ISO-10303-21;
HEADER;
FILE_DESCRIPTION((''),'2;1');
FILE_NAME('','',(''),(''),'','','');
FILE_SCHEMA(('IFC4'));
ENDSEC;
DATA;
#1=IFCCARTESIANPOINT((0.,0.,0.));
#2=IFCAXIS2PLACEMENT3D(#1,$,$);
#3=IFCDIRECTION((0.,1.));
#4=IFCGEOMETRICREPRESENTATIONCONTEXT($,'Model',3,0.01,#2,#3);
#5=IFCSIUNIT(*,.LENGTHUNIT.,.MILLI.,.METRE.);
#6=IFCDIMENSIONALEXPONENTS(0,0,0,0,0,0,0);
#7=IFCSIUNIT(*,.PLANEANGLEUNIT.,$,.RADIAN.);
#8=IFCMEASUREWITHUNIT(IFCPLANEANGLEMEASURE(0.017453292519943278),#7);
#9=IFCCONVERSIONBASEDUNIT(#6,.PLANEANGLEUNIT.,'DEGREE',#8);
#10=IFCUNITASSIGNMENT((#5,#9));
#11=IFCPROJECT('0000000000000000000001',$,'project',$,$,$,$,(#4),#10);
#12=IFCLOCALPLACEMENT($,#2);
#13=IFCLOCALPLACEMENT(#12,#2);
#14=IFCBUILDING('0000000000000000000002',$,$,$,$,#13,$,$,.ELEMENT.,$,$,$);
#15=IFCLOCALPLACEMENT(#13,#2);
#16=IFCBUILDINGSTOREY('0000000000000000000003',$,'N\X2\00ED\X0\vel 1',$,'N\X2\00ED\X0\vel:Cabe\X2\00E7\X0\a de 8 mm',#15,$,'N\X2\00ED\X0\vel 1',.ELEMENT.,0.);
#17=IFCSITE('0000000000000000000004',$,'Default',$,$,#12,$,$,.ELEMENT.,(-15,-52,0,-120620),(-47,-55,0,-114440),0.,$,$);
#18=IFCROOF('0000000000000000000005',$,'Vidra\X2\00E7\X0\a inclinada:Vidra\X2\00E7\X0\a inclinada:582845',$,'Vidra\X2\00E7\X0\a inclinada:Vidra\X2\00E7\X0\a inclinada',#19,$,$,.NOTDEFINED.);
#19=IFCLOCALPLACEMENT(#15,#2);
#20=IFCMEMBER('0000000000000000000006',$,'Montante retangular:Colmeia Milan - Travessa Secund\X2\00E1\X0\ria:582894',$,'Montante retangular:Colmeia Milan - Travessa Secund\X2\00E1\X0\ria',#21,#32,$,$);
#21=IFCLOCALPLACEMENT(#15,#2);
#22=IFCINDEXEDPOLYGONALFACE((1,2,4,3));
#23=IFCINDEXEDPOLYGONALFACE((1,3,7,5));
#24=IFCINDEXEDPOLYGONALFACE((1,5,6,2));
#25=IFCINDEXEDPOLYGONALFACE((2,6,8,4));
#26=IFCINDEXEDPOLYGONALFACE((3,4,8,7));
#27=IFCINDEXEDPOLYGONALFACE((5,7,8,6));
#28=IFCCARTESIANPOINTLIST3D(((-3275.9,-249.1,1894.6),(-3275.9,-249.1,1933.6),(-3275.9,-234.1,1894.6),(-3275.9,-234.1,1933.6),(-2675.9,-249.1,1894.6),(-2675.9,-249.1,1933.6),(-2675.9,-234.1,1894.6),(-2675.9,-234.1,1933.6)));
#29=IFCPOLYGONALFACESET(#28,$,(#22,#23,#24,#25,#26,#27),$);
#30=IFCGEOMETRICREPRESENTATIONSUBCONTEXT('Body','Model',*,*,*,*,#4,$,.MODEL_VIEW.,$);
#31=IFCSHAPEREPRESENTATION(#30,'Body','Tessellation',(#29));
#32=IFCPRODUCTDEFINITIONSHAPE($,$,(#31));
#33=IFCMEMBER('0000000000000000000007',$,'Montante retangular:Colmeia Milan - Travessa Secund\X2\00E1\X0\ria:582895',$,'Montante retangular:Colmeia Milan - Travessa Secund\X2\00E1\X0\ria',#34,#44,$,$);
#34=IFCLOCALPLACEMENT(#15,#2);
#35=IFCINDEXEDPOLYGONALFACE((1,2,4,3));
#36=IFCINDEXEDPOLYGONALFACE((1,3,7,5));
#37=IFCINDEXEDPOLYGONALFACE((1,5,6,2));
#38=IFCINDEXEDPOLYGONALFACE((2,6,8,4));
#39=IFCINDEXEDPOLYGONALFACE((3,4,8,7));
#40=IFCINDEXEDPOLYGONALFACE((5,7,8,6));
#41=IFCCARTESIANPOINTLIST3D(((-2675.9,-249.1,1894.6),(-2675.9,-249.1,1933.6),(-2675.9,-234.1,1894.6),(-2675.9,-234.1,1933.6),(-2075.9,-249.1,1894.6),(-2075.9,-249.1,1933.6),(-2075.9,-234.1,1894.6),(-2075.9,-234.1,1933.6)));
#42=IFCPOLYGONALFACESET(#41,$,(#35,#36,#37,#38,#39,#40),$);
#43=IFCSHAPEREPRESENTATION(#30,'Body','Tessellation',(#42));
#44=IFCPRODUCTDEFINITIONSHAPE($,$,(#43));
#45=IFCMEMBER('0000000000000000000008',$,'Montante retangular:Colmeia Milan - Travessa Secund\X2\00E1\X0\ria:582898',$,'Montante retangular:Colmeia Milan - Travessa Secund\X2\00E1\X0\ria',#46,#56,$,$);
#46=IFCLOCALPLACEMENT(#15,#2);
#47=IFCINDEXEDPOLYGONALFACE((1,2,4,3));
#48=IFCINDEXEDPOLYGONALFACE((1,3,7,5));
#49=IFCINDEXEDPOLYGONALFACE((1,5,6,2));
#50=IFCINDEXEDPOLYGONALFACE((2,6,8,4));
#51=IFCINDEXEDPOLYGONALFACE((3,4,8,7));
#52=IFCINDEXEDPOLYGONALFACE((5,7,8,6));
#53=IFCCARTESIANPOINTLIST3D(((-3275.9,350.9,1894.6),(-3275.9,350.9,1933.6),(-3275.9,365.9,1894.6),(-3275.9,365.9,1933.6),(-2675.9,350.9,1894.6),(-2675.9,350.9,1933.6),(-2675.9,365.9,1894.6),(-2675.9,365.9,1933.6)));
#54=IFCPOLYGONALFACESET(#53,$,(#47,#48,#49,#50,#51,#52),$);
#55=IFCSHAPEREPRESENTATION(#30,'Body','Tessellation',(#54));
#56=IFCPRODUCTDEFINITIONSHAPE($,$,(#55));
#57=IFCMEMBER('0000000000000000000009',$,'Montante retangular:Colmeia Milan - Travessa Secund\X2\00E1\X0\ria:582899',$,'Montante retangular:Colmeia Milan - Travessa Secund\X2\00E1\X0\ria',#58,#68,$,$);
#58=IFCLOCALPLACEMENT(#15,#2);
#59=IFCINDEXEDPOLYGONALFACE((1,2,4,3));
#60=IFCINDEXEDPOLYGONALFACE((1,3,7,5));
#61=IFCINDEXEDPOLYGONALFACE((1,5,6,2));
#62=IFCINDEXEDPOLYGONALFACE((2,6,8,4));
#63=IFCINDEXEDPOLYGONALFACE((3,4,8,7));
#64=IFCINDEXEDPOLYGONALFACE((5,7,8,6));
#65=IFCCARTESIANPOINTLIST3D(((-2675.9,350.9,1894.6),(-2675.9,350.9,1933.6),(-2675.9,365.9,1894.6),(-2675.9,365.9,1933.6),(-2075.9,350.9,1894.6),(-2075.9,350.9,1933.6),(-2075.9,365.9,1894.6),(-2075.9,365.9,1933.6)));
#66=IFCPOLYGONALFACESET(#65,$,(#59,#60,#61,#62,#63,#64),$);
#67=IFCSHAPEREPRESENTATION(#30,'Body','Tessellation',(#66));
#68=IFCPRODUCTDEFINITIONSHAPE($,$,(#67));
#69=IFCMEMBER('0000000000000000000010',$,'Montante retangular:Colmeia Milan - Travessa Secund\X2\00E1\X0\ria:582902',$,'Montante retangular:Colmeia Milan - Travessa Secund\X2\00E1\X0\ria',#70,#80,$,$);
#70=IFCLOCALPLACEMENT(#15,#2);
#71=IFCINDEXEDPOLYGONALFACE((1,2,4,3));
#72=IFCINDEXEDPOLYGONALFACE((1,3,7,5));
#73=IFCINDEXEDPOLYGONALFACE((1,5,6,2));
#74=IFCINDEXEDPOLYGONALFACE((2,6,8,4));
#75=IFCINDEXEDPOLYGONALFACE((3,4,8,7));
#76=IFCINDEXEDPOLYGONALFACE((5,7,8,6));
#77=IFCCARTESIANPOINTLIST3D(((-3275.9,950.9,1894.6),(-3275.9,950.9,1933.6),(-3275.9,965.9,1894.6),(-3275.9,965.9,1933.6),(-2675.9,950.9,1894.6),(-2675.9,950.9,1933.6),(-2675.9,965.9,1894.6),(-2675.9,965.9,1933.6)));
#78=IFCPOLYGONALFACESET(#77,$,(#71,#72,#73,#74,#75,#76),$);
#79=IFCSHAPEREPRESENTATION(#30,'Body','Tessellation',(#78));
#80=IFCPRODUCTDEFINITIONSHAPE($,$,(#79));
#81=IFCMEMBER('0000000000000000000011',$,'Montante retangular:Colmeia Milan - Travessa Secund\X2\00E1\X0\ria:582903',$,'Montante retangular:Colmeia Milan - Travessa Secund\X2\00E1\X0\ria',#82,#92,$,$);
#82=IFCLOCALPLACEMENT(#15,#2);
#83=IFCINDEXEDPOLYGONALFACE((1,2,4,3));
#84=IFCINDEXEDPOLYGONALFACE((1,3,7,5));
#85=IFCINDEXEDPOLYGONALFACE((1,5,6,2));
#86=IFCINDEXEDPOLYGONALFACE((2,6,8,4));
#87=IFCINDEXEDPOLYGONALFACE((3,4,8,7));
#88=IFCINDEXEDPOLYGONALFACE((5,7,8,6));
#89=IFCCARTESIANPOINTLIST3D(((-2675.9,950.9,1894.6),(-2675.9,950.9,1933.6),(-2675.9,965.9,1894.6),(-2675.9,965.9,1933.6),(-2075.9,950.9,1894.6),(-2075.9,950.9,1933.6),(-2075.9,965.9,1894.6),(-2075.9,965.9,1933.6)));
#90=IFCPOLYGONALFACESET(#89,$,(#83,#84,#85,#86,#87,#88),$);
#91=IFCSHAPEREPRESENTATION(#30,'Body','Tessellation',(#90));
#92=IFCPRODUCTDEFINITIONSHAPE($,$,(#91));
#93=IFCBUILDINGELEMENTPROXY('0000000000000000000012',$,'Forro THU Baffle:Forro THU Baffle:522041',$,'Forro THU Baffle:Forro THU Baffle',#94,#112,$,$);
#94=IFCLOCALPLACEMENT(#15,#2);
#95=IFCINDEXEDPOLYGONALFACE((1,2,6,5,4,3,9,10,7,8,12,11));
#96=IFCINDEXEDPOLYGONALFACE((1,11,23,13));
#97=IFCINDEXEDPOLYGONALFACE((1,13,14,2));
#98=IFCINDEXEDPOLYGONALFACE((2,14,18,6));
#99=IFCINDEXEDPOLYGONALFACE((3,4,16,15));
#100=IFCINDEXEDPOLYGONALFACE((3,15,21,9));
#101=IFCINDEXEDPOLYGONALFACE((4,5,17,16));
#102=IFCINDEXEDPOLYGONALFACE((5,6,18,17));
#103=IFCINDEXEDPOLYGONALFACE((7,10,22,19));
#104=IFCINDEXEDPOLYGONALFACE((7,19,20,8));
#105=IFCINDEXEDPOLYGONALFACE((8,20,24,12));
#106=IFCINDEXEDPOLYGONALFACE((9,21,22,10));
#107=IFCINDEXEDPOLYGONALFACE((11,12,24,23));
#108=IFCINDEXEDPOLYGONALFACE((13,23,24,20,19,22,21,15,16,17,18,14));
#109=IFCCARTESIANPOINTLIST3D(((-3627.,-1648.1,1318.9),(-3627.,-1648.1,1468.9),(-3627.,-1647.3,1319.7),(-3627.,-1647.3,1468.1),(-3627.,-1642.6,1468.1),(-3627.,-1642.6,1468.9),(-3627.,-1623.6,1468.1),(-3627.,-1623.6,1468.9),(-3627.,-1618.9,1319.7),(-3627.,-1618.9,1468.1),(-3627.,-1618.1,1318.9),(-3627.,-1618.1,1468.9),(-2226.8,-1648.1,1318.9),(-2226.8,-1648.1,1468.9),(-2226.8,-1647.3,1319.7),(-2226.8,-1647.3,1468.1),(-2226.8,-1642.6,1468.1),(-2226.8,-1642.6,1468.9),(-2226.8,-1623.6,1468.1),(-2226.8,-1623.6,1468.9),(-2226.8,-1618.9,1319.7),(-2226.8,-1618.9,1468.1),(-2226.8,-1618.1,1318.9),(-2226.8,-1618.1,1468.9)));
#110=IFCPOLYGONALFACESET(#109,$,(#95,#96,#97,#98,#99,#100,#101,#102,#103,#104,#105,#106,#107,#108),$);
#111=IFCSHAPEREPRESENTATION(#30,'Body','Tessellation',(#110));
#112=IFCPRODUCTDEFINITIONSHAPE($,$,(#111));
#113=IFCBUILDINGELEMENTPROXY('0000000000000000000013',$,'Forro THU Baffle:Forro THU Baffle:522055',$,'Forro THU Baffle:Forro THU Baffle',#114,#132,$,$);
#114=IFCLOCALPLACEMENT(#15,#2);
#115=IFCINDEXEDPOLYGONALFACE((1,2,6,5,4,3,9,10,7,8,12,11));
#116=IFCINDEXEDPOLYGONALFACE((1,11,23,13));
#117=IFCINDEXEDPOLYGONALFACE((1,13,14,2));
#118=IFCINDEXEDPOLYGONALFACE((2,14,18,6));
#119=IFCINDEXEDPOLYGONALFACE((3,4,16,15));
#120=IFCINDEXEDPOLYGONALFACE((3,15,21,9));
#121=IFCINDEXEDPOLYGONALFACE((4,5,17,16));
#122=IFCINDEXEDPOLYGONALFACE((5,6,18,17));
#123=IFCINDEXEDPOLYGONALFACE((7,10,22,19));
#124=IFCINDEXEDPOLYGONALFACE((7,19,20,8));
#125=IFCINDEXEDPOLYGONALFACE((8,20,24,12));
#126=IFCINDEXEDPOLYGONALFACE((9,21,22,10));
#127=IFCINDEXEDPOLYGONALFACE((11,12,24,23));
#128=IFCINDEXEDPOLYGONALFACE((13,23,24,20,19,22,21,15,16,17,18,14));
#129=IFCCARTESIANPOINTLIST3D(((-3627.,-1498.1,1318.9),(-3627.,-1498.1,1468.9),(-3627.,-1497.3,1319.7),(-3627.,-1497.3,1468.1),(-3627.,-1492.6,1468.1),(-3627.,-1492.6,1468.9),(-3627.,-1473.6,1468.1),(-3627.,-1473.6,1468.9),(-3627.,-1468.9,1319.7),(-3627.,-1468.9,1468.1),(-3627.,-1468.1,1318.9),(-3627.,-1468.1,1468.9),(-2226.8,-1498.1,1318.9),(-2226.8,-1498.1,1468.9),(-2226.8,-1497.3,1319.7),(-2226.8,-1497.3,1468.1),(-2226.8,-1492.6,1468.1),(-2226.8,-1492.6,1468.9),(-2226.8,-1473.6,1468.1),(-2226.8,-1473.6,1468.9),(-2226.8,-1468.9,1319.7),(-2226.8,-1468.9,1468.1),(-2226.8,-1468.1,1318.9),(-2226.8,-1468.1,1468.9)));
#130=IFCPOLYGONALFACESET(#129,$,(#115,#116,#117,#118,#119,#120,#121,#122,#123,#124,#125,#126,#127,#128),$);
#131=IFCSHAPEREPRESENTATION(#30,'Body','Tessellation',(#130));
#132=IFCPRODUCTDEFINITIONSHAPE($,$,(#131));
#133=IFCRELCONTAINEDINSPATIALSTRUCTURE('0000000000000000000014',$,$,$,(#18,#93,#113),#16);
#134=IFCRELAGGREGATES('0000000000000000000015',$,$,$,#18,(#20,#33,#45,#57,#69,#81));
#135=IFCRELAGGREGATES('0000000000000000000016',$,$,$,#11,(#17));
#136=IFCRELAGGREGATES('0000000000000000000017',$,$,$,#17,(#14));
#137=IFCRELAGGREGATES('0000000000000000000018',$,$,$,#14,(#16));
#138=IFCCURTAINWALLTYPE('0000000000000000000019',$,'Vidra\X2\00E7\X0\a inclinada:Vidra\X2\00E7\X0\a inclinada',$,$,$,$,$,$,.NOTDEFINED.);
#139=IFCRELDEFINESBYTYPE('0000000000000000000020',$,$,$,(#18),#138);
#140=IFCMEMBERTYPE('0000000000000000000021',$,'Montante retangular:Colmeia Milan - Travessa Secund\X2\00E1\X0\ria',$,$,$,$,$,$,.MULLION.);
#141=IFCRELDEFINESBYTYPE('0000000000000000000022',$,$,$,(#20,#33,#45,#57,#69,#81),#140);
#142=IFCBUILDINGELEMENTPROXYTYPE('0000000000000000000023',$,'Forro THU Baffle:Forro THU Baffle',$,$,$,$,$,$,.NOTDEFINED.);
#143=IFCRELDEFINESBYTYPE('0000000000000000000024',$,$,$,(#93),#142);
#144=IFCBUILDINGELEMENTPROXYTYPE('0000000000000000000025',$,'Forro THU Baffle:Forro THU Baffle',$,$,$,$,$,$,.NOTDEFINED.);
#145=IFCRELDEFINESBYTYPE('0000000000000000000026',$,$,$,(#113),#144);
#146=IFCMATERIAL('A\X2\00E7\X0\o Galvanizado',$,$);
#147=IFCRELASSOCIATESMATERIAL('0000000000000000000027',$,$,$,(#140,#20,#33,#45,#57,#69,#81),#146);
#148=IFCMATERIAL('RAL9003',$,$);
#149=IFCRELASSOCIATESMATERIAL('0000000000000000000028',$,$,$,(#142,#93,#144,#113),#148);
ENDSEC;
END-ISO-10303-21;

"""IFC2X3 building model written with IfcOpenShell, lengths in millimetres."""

from ifc_helpers import new_model, entity, si_unit, converted_unit, direction, frame, origin, origin_2d_with_axis, place, context, subcontext, project, spatial, polyline, rectangle, outline, extrude, source, transform, mapped, material, type_object, type_shapes, element, aggregate, save


model = new_model("IFC2X3")

# Units and contexts
model_context = context("Model", 3, precision=0.01, world=origin(), true_north=direction((0.0, 1.0)))
body_context = subcontext(model_context, "Body", "Model", "MODEL_VIEW")
ifc_project = project(units=[si_unit("LENGTHUNIT", "METRE", prefix="MILLI"), converted_unit("PLANEANGLEUNIT", "DEGREE", entity("IfcPlaneAngleMeasure", 0.017453292519943278), si_unit("PLANEANGLEUNIT", "RADIAN"), dimensions=[0, 0, 0, 0, 0, 0, 0])], contexts=[model_context])

# Site, building, storey
site_placement = place(None, origin())
site = spatial("IfcSite", under=ifc_project, at=site_placement, Name="Default", CompositionType="ELEMENT", RefLatitude=(-15, -52, 0, -120620), RefLongitude=(-47, -55, 0, -114440), RefElevation=0.0)
building_placement = place(site_placement, origin())
building = spatial("IfcBuilding", under=site, at=building_placement, CompositionType="ELEMENT")
storey_placement = place(building_placement, origin())
storey = spatial("IfcBuildingStorey", under=building, at=storey_placement, Name="Nível 1", ObjectType="Nível:Cabeça de 8 mm", LongName="Nível 1", CompositionType="ELEMENT", Elevation=0.0)

# Roof, members
curtain_wall_type = type_object("IfcCurtainWallType", Name="Vidraça inclinada:Vidraça inclinada", PredefinedType="NOTDEFINED")
roof_placement = place(storey_placement, origin())
roof = element("IfcRoof", 1, at=roof_placement, inside=storey, type_object=curtain_wall_type, Name="Vidraça inclinada:Vidraça inclinada:582845", ObjectType="Vidraça inclinada:Vidraça inclinada", ShapeType="NOTDEFINED")
ifc_material_1 = material(Name="Aço Galvanizado")
member_type_1 = type_object("IfcMemberType", Name="Montante retangular:Colmeia Milan - Travessa Secundária", PredefinedType="MULLION", material=ifc_material_1)
shared_shape_1 = source(origin(), body_context, "Body", "SweptSolid", [
    extrude(rectangle(XDim=15.0, YDim=39.0, at=origin_2d_with_axis()), frame((0.0, -19.5, -600.0), z_axis=(0.0, 0.0, 1.0), x_axis=(-1.0, 0.0, 0.0)), (0.0, 0.0, 1.0), 600.0),
])
type_shapes(member_type_1, [shared_shape_1])
member_1_placement = place(roof_placement, frame((-3275.9, -241.6, 1894.6), z_axis=(-1.0, 0.0, 0.0), x_axis=(0.0, 1.0, 0.0)))
member_1 = element("IfcMember", 2, at=member_1_placement, type_object=member_type_1, material=ifc_material_1, Name="Montante retangular:Colmeia Milan - Travessa Secundária:582894", ObjectType="Montante retangular:Colmeia Milan - Travessa Secundária", context=body_context, shape_type="MappedRepresentation", body=[
    mapped(shared_shape_1, transform((0.0, 0.0, 0.0), scale=1.0)),
])
member_2_placement = place(roof_placement, frame((-2675.9, -241.6, 1894.6), z_axis=(-1.0, 0.0, 0.0), x_axis=(0.0, 1.0, 0.0)))
member_2 = element("IfcMember", 3, at=member_2_placement, type_object=member_type_1, material=ifc_material_1, Name="Montante retangular:Colmeia Milan - Travessa Secundária:582895", ObjectType="Montante retangular:Colmeia Milan - Travessa Secundária", context=body_context, shape_type="MappedRepresentation", body=[
    mapped(shared_shape_1, transform((0.0, 0.0, 0.0), scale=1.0)),
])
member_3_placement = place(roof_placement, frame((-3275.9, 358.4, 1894.6), z_axis=(-1.0, 0.0, 0.0), x_axis=(0.0, 1.0, 0.0)))
member_3 = element("IfcMember", 4, at=member_3_placement, type_object=member_type_1, material=ifc_material_1, Name="Montante retangular:Colmeia Milan - Travessa Secundária:582898", ObjectType="Montante retangular:Colmeia Milan - Travessa Secundária", context=body_context, shape_type="MappedRepresentation", body=[
    mapped(shared_shape_1, transform((0.0, 0.0, 0.0), scale=1.0)),
])
member_4_placement = place(roof_placement, frame((-2675.9, 358.4, 1894.6), z_axis=(-1.0, 0.0, 0.0), x_axis=(0.0, 1.0, 0.0)))
member_4 = element("IfcMember", 5, at=member_4_placement, type_object=member_type_1, material=ifc_material_1, Name="Montante retangular:Colmeia Milan - Travessa Secundária:582899", ObjectType="Montante retangular:Colmeia Milan - Travessa Secundária", context=body_context, shape_type="MappedRepresentation", body=[
    mapped(shared_shape_1, transform((0.0, 0.0, 0.0), scale=1.0)),
])
member_5_placement = place(roof_placement, frame((-3275.9, 958.4, 1894.6), z_axis=(-1.0, 0.0, 0.0), x_axis=(0.0, 1.0, 0.0)))
member_5 = element("IfcMember", 6, at=member_5_placement, type_object=member_type_1, material=ifc_material_1, Name="Montante retangular:Colmeia Milan - Travessa Secundária:582902", ObjectType="Montante retangular:Colmeia Milan - Travessa Secundária", context=body_context, shape_type="MappedRepresentation", body=[
    mapped(shared_shape_1, transform((0.0, 0.0, 0.0), scale=1.0)),
])
member_6_placement = place(roof_placement, frame((-2675.9, 958.4, 1894.6), z_axis=(-1.0, 0.0, 0.0), x_axis=(0.0, 1.0, 0.0)))
member_6 = element("IfcMember", 7, at=member_6_placement, type_object=member_type_1, material=ifc_material_1, Name="Montante retangular:Colmeia Milan - Travessa Secundária:582903", ObjectType="Montante retangular:Colmeia Milan - Travessa Secundária", context=body_context, shape_type="MappedRepresentation", body=[
    mapped(shared_shape_1, transform((0.0, 0.0, 0.0), scale=1.0)),
])
aggregate(roof, [member_1, member_2, member_3, member_4, member_5, member_6])

# Building element proxies
ifc_material_2 = material(Name="RAL9003")
building_element_proxy_type_1 = type_object("IfcBuildingElementProxyType", Name="Forro THU Baffle:Forro THU Baffle", PredefinedType="NOTDEFINED", material=ifc_material_2)
shared_shape_2 = source(origin(), body_context, "Body", "SweptSolid", [
    extrude(outline(polyline([(-15.0, -99.9), (15.0, -99.9), (15.0, 50.1), (9.5, 50.1), (9.5, 49.3), (14.2, 49.3), (14.2, -99.1), (-14.2, -99.1), (-14.2, 49.3), (-9.5, 49.3), (-9.5, 50.1), (-15.0, 50.1), (-15.0, -99.9)])), frame((0.0, 15.0, -50.1), z_axis=(1.0, 0.0, 0.0), x_axis=(0.0, 1.0, 0.0)), (0.0, 0.0, 1.0), 1400.1),
])
type_shapes(building_element_proxy_type_1, [shared_shape_2])
proxy_1_placement = place(storey_placement, frame((-3627.0, -1648.1, 1468.9)))
element("IfcBuildingElementProxy", 8, at=proxy_1_placement, inside=storey, type_object=building_element_proxy_type_1, material=ifc_material_2, Name="Forro THU Baffle:Forro THU Baffle:522041", ObjectType="Forro THU Baffle:Forro THU Baffle", context=body_context, shape_type="MappedRepresentation", body=[
    mapped(shared_shape_2, transform((0.0, 0.0, 0.0), scale=1.0)),
])
building_element_proxy_type_2 = type_object("IfcBuildingElementProxyType", Name="Forro THU Baffle:Forro THU Baffle", PredefinedType="NOTDEFINED", material=ifc_material_2)
shared_shape_3 = source(origin(), body_context, "Body", "SweptSolid", [
    extrude(outline(polyline([(-15.0, -99.9), (15.0, -99.9), (15.0, 50.1), (9.5, 50.1), (9.5, 49.3), (14.2, 49.3), (14.2, -99.1), (-14.2, -99.1), (-14.2, 49.3), (-9.5, 49.3), (-9.5, 50.1), (-15.0, 50.1), (-15.0, -99.9)])), frame((0.0, 15.0, -50.1), z_axis=(1.0, 0.0, 0.0), x_axis=(0.0, 1.0, 0.0)), (0.0, 0.0, 1.0), 1400.1),
])
type_shapes(building_element_proxy_type_2, [shared_shape_3])
proxy_2_placement = place(storey_placement, frame((-3627.0, -1498.1, 1468.9)))
element("IfcBuildingElementProxy", 9, at=proxy_2_placement, inside=storey, type_object=building_element_proxy_type_2, material=ifc_material_2, Name="Forro THU Baffle:Forro THU Baffle:522055", ObjectType="Forro THU Baffle:Forro THU Baffle", context=body_context, shape_type="MappedRepresentation", body=[
    mapped(shared_shape_3, transform((0.0, 0.0, 0.0), scale=1.0)),
])

save(model, "model.ifc")
